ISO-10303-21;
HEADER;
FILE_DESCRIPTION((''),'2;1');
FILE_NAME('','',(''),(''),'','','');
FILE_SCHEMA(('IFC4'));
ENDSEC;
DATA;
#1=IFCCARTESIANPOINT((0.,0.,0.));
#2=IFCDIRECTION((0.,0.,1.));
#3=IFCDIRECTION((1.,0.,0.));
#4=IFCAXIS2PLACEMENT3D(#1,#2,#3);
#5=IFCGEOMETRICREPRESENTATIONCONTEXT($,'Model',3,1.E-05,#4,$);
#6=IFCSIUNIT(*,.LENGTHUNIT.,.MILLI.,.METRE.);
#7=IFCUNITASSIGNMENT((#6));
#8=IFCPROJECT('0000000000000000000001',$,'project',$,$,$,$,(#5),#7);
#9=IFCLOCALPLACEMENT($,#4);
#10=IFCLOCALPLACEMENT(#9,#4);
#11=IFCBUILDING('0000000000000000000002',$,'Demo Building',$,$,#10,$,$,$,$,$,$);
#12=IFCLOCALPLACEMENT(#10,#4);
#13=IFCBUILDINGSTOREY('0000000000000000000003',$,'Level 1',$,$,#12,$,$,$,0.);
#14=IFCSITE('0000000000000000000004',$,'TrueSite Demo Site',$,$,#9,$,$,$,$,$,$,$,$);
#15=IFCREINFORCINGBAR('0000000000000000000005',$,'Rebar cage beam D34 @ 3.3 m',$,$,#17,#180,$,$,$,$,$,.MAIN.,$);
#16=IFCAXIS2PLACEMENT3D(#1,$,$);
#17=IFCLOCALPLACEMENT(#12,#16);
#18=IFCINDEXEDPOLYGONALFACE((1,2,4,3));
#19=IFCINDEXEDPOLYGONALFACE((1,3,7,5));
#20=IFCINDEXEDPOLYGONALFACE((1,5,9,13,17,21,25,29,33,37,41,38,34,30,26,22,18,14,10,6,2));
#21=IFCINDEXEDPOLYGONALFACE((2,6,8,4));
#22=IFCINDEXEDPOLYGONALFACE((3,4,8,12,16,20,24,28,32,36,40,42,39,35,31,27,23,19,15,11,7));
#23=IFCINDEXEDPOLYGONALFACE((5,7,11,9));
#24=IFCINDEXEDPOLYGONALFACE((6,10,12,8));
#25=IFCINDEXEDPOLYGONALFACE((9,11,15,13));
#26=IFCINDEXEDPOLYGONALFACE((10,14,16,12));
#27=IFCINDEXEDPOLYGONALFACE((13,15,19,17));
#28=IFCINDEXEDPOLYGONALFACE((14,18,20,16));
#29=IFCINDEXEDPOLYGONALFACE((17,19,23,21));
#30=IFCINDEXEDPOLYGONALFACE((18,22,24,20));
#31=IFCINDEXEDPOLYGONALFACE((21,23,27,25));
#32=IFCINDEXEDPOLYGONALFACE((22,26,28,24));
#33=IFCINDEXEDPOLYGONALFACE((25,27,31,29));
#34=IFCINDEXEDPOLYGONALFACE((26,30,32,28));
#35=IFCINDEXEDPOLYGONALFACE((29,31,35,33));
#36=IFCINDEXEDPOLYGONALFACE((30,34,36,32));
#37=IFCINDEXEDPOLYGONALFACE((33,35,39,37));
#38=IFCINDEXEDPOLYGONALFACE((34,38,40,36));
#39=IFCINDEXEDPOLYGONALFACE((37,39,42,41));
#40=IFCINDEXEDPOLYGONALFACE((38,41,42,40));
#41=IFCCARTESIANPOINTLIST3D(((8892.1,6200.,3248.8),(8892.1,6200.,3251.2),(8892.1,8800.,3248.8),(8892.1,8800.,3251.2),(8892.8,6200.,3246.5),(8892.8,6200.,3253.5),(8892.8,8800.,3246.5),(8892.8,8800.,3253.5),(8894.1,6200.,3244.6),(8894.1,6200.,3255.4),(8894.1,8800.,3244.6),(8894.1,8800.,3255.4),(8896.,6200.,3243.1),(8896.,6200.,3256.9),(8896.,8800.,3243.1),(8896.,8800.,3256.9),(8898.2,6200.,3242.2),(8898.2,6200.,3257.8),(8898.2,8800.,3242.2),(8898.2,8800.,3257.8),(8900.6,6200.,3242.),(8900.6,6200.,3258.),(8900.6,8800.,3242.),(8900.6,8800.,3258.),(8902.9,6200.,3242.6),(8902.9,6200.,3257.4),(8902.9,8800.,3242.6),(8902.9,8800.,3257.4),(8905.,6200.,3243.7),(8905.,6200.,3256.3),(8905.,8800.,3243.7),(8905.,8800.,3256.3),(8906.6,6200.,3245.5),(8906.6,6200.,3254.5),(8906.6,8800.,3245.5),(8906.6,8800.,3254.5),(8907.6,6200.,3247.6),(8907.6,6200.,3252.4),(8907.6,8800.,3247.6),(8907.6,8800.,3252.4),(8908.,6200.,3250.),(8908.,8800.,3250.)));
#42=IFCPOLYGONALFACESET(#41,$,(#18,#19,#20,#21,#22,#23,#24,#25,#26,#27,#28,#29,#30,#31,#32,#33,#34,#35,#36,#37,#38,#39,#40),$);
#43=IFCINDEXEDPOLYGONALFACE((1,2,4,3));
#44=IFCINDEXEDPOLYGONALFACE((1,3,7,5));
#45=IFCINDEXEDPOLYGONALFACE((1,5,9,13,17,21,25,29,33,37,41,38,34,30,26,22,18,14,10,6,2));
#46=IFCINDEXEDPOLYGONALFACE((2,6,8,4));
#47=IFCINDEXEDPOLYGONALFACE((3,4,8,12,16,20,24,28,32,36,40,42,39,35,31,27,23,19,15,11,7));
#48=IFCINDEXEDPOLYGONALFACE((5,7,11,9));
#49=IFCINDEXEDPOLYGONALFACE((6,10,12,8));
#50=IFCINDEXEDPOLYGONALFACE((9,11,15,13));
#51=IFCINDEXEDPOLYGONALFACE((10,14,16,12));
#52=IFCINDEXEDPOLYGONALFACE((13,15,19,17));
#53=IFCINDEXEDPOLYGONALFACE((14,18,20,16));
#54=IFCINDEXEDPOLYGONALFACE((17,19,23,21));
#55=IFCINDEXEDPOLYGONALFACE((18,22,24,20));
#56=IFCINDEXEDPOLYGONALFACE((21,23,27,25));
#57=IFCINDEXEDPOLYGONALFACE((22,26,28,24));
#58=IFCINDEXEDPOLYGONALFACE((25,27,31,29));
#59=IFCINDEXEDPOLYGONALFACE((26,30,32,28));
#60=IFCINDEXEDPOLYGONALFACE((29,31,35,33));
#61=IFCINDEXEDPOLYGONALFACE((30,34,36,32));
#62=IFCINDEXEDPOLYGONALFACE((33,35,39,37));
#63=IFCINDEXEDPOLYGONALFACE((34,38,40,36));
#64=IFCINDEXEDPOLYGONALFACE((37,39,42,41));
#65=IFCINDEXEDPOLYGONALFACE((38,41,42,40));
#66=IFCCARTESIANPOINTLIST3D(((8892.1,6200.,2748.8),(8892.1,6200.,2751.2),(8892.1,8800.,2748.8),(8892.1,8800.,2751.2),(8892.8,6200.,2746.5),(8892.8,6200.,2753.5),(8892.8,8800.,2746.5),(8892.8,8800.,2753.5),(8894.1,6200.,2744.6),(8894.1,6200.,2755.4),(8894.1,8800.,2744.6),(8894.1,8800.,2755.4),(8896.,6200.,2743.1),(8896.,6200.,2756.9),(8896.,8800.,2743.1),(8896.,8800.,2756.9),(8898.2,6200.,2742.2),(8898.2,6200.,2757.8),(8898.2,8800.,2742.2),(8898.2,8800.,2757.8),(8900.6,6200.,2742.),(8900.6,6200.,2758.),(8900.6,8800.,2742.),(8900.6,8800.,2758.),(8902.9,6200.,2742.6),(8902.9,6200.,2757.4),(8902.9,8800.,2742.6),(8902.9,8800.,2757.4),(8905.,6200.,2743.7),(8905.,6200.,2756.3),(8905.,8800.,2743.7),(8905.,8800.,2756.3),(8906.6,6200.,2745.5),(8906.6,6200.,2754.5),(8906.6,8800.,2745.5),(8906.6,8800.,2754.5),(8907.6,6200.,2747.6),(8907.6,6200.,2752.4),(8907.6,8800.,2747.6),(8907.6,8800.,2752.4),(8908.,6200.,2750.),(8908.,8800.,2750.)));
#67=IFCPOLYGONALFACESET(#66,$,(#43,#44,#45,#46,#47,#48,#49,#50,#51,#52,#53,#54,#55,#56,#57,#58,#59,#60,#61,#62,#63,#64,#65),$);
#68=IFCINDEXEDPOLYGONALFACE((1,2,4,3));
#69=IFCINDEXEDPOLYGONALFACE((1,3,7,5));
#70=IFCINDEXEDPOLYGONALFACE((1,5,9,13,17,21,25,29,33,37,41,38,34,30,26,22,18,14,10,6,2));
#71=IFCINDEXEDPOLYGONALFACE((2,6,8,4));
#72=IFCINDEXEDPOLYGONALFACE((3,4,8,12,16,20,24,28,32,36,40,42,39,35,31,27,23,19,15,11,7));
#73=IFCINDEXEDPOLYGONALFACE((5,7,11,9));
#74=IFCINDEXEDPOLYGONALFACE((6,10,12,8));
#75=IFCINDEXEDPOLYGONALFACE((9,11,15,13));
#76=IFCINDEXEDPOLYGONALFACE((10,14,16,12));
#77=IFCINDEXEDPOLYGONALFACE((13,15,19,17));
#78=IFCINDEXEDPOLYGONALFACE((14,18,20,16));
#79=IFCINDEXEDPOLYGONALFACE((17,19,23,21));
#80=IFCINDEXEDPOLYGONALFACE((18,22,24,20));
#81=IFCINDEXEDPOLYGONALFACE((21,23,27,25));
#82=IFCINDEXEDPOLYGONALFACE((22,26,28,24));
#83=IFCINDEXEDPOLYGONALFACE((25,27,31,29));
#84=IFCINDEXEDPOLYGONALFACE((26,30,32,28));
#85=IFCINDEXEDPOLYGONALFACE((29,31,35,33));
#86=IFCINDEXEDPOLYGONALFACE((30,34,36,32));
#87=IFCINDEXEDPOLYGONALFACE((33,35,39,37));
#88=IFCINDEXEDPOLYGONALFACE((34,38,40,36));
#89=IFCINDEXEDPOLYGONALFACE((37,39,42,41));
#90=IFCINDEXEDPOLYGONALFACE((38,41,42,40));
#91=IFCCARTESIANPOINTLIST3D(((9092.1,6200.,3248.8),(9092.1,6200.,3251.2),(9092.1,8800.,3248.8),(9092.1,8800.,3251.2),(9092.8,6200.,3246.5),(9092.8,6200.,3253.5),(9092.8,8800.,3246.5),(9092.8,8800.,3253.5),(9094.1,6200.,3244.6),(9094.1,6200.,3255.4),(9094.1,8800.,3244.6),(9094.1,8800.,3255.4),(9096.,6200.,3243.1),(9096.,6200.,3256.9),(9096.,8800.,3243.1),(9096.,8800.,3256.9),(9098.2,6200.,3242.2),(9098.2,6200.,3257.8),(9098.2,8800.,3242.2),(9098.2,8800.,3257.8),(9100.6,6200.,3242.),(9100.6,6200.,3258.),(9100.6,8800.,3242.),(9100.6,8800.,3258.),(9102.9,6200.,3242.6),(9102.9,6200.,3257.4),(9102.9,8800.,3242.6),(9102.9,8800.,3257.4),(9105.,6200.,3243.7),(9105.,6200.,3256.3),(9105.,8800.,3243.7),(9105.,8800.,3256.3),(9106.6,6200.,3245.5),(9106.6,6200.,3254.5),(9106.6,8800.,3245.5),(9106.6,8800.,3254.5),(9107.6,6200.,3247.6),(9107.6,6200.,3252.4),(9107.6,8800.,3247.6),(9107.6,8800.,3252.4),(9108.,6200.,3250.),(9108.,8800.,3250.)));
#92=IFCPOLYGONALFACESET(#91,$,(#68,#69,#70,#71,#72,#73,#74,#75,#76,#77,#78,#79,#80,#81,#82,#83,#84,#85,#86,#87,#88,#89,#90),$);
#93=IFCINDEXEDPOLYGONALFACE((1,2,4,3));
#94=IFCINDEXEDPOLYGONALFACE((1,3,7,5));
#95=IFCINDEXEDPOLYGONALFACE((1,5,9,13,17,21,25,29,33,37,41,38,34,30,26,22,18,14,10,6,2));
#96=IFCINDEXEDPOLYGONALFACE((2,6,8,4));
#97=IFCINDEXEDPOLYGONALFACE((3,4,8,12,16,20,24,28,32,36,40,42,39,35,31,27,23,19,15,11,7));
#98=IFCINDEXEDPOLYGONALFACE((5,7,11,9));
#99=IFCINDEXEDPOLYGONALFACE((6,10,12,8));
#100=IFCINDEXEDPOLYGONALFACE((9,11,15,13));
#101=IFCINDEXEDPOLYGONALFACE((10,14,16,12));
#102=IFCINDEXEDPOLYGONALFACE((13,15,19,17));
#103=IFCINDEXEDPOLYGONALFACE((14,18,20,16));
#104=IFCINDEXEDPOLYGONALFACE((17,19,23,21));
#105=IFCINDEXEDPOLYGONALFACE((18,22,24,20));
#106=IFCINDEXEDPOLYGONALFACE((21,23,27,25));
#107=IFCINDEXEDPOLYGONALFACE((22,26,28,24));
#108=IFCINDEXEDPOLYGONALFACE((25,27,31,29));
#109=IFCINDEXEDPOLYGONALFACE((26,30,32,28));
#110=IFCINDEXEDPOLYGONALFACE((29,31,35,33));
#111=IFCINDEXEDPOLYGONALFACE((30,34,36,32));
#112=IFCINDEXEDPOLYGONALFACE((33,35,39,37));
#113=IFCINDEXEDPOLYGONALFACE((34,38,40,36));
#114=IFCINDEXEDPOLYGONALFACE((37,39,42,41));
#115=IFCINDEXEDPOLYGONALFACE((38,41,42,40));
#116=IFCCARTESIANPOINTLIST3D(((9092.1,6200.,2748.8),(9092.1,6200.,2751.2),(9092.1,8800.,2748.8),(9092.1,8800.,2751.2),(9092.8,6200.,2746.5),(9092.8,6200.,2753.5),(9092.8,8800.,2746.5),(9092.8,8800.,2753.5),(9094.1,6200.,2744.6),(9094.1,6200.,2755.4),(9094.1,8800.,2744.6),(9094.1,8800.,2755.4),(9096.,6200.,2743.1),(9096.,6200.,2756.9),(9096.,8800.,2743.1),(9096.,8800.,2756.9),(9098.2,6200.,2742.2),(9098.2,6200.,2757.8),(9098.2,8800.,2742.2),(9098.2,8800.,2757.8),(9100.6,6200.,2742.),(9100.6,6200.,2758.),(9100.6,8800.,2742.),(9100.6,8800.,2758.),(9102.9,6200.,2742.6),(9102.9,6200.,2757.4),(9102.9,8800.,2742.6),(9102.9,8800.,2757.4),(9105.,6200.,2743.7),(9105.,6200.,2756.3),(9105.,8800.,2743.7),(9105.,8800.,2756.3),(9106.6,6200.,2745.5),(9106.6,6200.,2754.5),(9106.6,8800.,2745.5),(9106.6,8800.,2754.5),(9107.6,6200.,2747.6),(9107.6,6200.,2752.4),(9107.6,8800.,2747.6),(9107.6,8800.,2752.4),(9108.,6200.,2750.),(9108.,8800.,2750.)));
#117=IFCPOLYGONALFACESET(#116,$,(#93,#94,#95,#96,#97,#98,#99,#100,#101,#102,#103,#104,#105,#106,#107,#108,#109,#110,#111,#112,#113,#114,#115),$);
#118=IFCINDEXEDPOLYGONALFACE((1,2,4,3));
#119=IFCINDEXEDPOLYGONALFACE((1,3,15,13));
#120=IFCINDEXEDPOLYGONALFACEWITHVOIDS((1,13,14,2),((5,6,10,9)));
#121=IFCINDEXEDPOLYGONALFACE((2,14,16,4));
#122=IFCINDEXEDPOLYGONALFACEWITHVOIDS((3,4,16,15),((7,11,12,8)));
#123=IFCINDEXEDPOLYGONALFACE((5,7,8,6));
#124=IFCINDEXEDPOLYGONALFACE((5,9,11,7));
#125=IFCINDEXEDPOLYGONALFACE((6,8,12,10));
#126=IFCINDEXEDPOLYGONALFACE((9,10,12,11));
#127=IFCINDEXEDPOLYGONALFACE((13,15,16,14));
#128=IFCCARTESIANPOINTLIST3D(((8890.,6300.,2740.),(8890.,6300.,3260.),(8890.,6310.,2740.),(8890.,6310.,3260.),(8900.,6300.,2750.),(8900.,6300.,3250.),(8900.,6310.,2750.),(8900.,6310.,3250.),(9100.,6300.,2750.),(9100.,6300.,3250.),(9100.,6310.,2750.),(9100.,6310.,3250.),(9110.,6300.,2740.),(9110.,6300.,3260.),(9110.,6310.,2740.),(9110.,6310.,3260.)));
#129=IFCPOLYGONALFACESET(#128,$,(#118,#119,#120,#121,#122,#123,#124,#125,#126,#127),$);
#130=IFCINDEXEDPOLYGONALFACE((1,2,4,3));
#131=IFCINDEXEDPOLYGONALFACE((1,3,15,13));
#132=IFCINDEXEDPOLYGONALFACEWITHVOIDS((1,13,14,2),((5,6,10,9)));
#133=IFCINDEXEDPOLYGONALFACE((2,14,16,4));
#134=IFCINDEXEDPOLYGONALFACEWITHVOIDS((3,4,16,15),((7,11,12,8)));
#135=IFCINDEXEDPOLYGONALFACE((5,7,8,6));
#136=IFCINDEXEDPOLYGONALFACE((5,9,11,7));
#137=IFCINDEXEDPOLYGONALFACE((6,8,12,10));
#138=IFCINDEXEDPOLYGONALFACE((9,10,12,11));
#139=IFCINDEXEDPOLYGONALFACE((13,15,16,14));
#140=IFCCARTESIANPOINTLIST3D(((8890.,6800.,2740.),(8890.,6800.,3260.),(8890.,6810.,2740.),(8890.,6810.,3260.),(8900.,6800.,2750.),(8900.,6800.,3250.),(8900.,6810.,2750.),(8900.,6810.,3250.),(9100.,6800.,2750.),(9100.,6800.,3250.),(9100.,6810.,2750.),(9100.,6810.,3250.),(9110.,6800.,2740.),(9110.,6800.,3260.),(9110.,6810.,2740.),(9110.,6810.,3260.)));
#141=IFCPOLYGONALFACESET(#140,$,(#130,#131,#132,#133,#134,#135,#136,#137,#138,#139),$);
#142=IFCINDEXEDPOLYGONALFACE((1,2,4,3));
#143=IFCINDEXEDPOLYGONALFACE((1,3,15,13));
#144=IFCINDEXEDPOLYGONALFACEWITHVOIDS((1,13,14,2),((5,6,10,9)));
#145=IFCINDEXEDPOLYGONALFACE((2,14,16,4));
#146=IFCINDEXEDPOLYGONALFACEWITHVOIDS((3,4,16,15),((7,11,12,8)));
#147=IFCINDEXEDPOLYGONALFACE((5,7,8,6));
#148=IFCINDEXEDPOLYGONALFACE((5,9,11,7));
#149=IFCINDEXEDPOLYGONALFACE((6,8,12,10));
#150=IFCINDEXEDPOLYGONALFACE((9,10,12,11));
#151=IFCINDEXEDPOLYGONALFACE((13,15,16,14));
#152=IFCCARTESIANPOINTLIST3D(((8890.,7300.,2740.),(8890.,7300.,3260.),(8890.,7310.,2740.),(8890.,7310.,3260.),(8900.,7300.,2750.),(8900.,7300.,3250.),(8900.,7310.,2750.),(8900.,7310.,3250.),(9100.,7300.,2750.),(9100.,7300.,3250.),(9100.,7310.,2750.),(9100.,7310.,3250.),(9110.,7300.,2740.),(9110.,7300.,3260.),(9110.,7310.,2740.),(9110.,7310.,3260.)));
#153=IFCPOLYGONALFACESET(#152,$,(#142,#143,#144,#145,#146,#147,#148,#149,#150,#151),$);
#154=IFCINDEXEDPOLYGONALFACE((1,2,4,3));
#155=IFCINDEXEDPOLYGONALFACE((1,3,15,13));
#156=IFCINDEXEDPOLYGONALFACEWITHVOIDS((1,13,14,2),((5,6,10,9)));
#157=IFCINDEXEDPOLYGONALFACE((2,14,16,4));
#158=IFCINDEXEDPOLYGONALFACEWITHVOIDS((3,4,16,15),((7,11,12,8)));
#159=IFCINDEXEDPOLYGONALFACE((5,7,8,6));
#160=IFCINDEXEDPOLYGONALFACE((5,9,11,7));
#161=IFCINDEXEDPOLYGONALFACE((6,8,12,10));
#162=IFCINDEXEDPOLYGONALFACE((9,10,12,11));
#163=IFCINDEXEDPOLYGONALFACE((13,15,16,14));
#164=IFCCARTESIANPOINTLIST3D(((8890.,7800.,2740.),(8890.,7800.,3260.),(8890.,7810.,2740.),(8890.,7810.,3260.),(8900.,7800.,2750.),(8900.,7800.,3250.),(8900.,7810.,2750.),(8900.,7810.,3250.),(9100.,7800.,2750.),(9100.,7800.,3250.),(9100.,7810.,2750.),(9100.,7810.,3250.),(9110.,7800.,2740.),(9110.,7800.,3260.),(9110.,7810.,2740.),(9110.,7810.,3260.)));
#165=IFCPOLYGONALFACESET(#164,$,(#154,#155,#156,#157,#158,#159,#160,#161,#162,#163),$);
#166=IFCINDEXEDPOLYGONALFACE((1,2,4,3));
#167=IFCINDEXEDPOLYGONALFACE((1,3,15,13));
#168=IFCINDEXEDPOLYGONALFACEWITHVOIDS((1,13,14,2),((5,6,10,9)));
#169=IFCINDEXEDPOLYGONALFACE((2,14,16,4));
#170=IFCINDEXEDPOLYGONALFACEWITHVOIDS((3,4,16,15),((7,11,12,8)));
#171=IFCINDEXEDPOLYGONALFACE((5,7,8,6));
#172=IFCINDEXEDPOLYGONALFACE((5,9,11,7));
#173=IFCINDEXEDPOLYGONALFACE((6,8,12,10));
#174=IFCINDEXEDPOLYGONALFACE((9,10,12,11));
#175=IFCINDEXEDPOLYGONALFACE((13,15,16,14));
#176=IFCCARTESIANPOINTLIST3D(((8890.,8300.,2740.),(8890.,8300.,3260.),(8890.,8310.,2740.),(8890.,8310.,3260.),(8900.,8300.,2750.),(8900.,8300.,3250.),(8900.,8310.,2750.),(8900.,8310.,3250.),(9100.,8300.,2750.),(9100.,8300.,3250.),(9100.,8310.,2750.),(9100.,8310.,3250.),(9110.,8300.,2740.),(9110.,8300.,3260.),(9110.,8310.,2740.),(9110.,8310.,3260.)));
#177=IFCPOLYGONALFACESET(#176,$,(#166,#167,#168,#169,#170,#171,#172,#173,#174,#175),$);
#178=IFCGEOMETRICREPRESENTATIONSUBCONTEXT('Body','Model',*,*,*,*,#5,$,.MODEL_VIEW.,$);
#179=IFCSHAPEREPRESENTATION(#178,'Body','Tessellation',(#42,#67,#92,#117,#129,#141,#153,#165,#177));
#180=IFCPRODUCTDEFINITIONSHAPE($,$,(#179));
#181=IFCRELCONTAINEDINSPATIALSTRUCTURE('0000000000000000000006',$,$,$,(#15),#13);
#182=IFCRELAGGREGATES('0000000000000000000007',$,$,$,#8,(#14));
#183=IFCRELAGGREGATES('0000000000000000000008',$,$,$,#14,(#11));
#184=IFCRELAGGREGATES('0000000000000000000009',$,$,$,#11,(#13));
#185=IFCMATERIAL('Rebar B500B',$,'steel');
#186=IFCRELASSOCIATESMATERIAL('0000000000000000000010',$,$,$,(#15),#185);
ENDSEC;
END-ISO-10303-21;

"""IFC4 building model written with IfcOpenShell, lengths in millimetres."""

from ifc_helpers import new_model, si_unit, frame, origin_with_axes, place, context, subcontext, project, spatial, hollow_rectangle, circle, extrude, material, element, save


model = new_model("IFC4")

# Units and contexts
model_context = context("Model", 3, precision=1e-05, world=origin_with_axes())
body_context = subcontext(model_context, "Body", "Model", "MODEL_VIEW")
ifc_project = project(units=[si_unit("LENGTHUNIT", "METRE", prefix="MILLI")], contexts=[model_context])

# Site, building, storey
site_placement = place(None, origin_with_axes())
site = spatial("IfcSite", under=ifc_project, at=site_placement, Name="TrueSite Demo Site")
building_placement = place(site_placement, origin_with_axes())
building = spatial("IfcBuilding", under=site, at=building_placement, Name="Demo Building")
storey_placement = place(building_placement, origin_with_axes())
storey = spatial("IfcBuildingStorey", under=building, at=storey_placement, Name="Level 1", Elevation=0.0)

# Reinforcing bar
ifc_material_1 = material(Name="Rebar B500B", Category="steel")
for number, where, z_axis, x_axis, name in (
    (1, (9000.0, 6200.0, 3000.0), (0.0, 1.0, 0.0), (1.0, 0.0, 0.0), "Rebar cage beam D34 @ 3.3 m"),
):
    element("IfcReinforcingBar", number, at=place(storey_placement, frame(where, z_axis=z_axis, x_axis=x_axis)), inside=storey, material=ifc_material_1, Name=name, PredefinedType="MAIN", context=body_context, shape_type="SweptSolid", body=[
        extrude(circle(Radius=8.0), frame((-100.0, -250.0, 0.0)), (0.0, 0.0, 1.0), 2600.0),
        extrude(circle(Radius=8.0), frame((-100.0, 250.0, 0.0)), (0.0, 0.0, 1.0), 2600.0),
        extrude(circle(Radius=8.0), frame((100.0, -250.0, 0.0)), (0.0, 0.0, 1.0), 2600.0),
        extrude(circle(Radius=8.0), frame((100.0, 250.0, 0.0)), (0.0, 0.0, 1.0), 2600.0),
        extrude(hollow_rectangle(XDim=220.0, YDim=520.0, WallThickness=10.0), frame((0.0, 0.0, 100.0)), (0.0, 0.0, 1.0), 10.0),
        extrude(hollow_rectangle(XDim=220.0, YDim=520.0, WallThickness=10.0), frame((0.0, 0.0, 600.0)), (0.0, 0.0, 1.0), 10.0),
        extrude(hollow_rectangle(XDim=220.0, YDim=520.0, WallThickness=10.0), frame((0.0, 0.0, 1100.0)), (0.0, 0.0, 1.0), 10.0),
        extrude(hollow_rectangle(XDim=220.0, YDim=520.0, WallThickness=10.0), frame((0.0, 0.0, 1600.0)), (0.0, 0.0, 1.0), 10.0),
        extrude(hollow_rectangle(XDim=220.0, YDim=520.0, WallThickness=10.0), frame((0.0, 0.0, 2100.0)), (0.0, 0.0, 1.0), 10.0),
    ])

save(model, "model.ifc")
